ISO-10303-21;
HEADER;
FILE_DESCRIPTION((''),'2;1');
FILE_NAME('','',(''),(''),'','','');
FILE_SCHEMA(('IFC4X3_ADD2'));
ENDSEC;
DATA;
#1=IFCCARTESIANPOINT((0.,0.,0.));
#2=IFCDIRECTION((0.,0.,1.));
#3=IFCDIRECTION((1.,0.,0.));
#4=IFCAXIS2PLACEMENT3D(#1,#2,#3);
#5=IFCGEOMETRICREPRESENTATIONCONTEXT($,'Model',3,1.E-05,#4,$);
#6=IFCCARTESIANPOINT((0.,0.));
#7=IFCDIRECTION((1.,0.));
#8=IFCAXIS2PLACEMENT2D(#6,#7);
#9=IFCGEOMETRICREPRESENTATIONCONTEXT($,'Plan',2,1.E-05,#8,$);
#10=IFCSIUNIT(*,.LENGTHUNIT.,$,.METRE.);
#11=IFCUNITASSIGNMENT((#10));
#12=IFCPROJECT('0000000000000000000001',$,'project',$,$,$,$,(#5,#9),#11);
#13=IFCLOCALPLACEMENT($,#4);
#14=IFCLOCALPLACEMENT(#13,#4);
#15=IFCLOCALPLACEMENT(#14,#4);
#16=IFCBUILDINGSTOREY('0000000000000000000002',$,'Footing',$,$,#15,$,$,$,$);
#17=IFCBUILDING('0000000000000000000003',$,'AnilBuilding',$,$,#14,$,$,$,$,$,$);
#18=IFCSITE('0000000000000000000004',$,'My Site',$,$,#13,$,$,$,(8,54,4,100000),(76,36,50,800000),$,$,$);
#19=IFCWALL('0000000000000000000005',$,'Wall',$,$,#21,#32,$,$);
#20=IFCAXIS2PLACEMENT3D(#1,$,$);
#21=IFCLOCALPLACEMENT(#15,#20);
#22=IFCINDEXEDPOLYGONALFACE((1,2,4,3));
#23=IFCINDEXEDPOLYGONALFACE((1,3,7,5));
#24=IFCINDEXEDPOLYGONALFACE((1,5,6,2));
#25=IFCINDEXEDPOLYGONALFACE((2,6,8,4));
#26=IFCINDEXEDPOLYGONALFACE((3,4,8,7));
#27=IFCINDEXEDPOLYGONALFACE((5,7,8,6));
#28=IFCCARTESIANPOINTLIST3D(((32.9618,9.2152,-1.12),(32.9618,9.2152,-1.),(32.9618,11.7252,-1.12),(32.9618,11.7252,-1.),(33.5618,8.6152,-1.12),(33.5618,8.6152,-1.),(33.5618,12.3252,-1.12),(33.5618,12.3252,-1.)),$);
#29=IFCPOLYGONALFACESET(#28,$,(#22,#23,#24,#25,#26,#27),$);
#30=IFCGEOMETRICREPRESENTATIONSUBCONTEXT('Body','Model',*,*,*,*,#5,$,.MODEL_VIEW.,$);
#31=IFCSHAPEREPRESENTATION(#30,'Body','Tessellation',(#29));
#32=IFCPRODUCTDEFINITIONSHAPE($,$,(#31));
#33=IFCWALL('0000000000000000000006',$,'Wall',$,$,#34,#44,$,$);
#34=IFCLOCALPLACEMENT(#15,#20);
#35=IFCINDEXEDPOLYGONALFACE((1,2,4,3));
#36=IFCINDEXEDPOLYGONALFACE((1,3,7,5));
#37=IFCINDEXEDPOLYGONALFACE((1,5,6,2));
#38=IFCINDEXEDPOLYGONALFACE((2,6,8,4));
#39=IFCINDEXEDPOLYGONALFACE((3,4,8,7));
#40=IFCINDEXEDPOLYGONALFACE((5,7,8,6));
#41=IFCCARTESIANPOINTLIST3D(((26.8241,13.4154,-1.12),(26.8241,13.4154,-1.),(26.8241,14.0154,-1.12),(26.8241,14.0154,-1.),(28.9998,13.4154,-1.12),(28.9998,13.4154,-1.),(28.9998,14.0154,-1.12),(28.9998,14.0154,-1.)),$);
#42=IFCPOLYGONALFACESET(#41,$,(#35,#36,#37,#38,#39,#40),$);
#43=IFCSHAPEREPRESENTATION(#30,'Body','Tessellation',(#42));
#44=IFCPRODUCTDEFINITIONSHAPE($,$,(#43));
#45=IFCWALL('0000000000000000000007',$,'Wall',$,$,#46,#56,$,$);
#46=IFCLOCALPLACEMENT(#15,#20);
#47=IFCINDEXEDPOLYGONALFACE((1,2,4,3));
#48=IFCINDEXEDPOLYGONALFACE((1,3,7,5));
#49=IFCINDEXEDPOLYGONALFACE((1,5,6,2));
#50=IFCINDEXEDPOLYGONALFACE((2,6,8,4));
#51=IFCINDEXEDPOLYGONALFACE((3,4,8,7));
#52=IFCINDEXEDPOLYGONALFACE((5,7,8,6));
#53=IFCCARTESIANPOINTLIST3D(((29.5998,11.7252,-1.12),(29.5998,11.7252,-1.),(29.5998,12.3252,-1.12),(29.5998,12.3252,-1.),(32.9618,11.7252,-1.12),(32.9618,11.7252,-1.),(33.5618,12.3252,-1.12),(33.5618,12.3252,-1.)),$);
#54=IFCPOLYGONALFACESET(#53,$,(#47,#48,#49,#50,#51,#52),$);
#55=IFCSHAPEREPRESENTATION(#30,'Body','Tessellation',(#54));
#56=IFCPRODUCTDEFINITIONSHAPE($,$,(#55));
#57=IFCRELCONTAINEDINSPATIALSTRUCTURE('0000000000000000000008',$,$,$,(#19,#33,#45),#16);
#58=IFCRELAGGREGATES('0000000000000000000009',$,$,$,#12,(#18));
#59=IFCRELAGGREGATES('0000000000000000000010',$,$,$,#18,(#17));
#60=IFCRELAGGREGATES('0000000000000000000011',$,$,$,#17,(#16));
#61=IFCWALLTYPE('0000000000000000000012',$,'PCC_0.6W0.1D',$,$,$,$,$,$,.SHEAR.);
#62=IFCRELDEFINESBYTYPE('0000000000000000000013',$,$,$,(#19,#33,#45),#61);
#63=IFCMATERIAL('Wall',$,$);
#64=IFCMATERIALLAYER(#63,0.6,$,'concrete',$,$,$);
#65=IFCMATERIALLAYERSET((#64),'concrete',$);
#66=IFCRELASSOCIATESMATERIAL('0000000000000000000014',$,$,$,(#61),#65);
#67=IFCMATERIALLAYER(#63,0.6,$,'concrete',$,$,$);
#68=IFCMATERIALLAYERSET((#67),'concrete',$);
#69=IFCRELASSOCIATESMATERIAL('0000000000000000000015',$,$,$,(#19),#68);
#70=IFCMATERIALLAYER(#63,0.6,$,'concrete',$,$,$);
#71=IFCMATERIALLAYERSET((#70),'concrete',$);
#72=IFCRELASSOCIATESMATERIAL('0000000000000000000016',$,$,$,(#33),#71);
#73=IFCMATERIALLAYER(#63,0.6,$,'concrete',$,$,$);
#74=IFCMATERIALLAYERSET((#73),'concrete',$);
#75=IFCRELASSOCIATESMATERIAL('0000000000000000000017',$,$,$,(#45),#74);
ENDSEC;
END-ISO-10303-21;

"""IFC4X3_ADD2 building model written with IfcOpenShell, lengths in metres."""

from ifc_helpers import new_model, si_unit, frame, origin_with_axes, origin_2d_with_axis, place, context, subcontext, project, spatial, line, indexed_curve, outline, extrude, material, layer, layer_set, layer_usage, type_object, element, save


model = new_model("IFC4X3_ADD2")

# Units and contexts
model_context = context("Model", 3, precision=1e-05, world=origin_with_axes())
plan_context = context("Plan", 2, precision=1e-05, world=origin_2d_with_axis())
body_context = subcontext(model_context, "Body", "Model", "MODEL_VIEW")
ifc_project = project(units=[si_unit("LENGTHUNIT", "METRE")], contexts=[model_context, plan_context])

# Site, building, storey
site_placement = place(None, origin_with_axes())
site = spatial("IfcSite", under=ifc_project, at=site_placement, Name="My Site", RefLatitude=(8, 54, 4, 100000), RefLongitude=(76, 36, 50, 800000))
building_placement = place(site_placement, origin_with_axes())
building = spatial("IfcBuilding", under=site, at=building_placement, Name="AnilBuilding")
storey_placement = place(building_placement, origin_with_axes())
storey = spatial("IfcBuildingStorey", under=building, at=storey_placement, Name="Footing")

# Shared definitions
ifc_material_1 = material(Name="Wall")

# Walls
ifc_layer_1 = layer(ifc_material_1, 0.6, Name="concrete")
ifc_layer_set_1 = layer_set([ifc_layer_1], Name="concrete")
wall_type_1 = type_object("IfcWallType", Name="PCC_0.6W0.1D", PredefinedType="SHEAR", material=ifc_layer_set_1)
ifc_layer_2 = layer(ifc_material_1, 0.6, Name="concrete")
ifc_layer_set_2 = layer_set([ifc_layer_2], Name="concrete")
ifc_layer_usage_1 = layer_usage(ifc_layer_set_2, "AXIS2", "POSITIVE", 0.0)
wall_1_placement = place(storey_placement, frame((33.5618, 8.6152, -1.12), z_axis=(0.0, 0.0, 1.0), x_axis=(0.0, 1.0, 0.0)))
element("IfcWall", 1, at=wall_1_placement, inside=storey, type_object=wall_type_1, material=ifc_layer_usage_1, Name="Wall", context=body_context, shape_type="SweptSolid", body=[
    extrude(outline(indexed_curve([(0.0, 0.0), (0.6, 0.6), (3.11, 0.6), (3.71, 0.0)], segments=[line(1, 2, 3, 4, 1)])), origin_with_axes(), (0.0, 0.0, 1.0), 0.12),
])
ifc_layer_3 = layer(ifc_material_1, 0.6, Name="concrete")
ifc_layer_set_3 = layer_set([ifc_layer_3], Name="concrete")
ifc_layer_usage_2 = layer_usage(ifc_layer_set_3, "AXIS2", "POSITIVE", 0.0)
wall_2_placement = place(storey_placement, frame((26.8241, 13.4154, -1.12), z_axis=(0.0, 0.0, 1.0), x_axis=(1.0, 0.0, 0.0)))
element("IfcWall", 2, at=wall_2_placement, inside=storey, type_object=wall_type_1, material=ifc_layer_usage_2, Name="Wall", context=body_context, shape_type="SweptSolid", body=[
    extrude(outline(indexed_curve([(0.0, 0.0), (0.0, 0.6), (2.1757, 0.6), (2.1757, 0.0)], segments=[line(1, 2, 3, 4, 1)])), origin_with_axes(), (0.0, 0.0, 1.0), 0.12),
])
ifc_layer_4 = layer(ifc_material_1, 0.6, Name="concrete")
ifc_layer_set_4 = layer_set([ifc_layer_4], Name="concrete")
ifc_layer_usage_3 = layer_usage(ifc_layer_set_4, "AXIS2", "POSITIVE", 0.0)
wall_3_placement = place(storey_placement, frame((29.5998, 11.7252, -1.12), z_axis=(0.0, 0.0, 1.0), x_axis=(1.0, 0.0, 0.0)))
element("IfcWall", 3, at=wall_3_placement, inside=storey, type_object=wall_type_1, material=ifc_layer_usage_3, Name="Wall", context=body_context, shape_type="SweptSolid", body=[
    extrude(outline(indexed_curve([(0.0, 0.0), (0.0, 0.6), (3.962, 0.6), (3.362, 0.0)], segments=[line(1, 2, 3, 4, 1)])), origin_with_axes(), (0.0, 0.0, 1.0), 0.12),
])

save(model, "model.ifc")
